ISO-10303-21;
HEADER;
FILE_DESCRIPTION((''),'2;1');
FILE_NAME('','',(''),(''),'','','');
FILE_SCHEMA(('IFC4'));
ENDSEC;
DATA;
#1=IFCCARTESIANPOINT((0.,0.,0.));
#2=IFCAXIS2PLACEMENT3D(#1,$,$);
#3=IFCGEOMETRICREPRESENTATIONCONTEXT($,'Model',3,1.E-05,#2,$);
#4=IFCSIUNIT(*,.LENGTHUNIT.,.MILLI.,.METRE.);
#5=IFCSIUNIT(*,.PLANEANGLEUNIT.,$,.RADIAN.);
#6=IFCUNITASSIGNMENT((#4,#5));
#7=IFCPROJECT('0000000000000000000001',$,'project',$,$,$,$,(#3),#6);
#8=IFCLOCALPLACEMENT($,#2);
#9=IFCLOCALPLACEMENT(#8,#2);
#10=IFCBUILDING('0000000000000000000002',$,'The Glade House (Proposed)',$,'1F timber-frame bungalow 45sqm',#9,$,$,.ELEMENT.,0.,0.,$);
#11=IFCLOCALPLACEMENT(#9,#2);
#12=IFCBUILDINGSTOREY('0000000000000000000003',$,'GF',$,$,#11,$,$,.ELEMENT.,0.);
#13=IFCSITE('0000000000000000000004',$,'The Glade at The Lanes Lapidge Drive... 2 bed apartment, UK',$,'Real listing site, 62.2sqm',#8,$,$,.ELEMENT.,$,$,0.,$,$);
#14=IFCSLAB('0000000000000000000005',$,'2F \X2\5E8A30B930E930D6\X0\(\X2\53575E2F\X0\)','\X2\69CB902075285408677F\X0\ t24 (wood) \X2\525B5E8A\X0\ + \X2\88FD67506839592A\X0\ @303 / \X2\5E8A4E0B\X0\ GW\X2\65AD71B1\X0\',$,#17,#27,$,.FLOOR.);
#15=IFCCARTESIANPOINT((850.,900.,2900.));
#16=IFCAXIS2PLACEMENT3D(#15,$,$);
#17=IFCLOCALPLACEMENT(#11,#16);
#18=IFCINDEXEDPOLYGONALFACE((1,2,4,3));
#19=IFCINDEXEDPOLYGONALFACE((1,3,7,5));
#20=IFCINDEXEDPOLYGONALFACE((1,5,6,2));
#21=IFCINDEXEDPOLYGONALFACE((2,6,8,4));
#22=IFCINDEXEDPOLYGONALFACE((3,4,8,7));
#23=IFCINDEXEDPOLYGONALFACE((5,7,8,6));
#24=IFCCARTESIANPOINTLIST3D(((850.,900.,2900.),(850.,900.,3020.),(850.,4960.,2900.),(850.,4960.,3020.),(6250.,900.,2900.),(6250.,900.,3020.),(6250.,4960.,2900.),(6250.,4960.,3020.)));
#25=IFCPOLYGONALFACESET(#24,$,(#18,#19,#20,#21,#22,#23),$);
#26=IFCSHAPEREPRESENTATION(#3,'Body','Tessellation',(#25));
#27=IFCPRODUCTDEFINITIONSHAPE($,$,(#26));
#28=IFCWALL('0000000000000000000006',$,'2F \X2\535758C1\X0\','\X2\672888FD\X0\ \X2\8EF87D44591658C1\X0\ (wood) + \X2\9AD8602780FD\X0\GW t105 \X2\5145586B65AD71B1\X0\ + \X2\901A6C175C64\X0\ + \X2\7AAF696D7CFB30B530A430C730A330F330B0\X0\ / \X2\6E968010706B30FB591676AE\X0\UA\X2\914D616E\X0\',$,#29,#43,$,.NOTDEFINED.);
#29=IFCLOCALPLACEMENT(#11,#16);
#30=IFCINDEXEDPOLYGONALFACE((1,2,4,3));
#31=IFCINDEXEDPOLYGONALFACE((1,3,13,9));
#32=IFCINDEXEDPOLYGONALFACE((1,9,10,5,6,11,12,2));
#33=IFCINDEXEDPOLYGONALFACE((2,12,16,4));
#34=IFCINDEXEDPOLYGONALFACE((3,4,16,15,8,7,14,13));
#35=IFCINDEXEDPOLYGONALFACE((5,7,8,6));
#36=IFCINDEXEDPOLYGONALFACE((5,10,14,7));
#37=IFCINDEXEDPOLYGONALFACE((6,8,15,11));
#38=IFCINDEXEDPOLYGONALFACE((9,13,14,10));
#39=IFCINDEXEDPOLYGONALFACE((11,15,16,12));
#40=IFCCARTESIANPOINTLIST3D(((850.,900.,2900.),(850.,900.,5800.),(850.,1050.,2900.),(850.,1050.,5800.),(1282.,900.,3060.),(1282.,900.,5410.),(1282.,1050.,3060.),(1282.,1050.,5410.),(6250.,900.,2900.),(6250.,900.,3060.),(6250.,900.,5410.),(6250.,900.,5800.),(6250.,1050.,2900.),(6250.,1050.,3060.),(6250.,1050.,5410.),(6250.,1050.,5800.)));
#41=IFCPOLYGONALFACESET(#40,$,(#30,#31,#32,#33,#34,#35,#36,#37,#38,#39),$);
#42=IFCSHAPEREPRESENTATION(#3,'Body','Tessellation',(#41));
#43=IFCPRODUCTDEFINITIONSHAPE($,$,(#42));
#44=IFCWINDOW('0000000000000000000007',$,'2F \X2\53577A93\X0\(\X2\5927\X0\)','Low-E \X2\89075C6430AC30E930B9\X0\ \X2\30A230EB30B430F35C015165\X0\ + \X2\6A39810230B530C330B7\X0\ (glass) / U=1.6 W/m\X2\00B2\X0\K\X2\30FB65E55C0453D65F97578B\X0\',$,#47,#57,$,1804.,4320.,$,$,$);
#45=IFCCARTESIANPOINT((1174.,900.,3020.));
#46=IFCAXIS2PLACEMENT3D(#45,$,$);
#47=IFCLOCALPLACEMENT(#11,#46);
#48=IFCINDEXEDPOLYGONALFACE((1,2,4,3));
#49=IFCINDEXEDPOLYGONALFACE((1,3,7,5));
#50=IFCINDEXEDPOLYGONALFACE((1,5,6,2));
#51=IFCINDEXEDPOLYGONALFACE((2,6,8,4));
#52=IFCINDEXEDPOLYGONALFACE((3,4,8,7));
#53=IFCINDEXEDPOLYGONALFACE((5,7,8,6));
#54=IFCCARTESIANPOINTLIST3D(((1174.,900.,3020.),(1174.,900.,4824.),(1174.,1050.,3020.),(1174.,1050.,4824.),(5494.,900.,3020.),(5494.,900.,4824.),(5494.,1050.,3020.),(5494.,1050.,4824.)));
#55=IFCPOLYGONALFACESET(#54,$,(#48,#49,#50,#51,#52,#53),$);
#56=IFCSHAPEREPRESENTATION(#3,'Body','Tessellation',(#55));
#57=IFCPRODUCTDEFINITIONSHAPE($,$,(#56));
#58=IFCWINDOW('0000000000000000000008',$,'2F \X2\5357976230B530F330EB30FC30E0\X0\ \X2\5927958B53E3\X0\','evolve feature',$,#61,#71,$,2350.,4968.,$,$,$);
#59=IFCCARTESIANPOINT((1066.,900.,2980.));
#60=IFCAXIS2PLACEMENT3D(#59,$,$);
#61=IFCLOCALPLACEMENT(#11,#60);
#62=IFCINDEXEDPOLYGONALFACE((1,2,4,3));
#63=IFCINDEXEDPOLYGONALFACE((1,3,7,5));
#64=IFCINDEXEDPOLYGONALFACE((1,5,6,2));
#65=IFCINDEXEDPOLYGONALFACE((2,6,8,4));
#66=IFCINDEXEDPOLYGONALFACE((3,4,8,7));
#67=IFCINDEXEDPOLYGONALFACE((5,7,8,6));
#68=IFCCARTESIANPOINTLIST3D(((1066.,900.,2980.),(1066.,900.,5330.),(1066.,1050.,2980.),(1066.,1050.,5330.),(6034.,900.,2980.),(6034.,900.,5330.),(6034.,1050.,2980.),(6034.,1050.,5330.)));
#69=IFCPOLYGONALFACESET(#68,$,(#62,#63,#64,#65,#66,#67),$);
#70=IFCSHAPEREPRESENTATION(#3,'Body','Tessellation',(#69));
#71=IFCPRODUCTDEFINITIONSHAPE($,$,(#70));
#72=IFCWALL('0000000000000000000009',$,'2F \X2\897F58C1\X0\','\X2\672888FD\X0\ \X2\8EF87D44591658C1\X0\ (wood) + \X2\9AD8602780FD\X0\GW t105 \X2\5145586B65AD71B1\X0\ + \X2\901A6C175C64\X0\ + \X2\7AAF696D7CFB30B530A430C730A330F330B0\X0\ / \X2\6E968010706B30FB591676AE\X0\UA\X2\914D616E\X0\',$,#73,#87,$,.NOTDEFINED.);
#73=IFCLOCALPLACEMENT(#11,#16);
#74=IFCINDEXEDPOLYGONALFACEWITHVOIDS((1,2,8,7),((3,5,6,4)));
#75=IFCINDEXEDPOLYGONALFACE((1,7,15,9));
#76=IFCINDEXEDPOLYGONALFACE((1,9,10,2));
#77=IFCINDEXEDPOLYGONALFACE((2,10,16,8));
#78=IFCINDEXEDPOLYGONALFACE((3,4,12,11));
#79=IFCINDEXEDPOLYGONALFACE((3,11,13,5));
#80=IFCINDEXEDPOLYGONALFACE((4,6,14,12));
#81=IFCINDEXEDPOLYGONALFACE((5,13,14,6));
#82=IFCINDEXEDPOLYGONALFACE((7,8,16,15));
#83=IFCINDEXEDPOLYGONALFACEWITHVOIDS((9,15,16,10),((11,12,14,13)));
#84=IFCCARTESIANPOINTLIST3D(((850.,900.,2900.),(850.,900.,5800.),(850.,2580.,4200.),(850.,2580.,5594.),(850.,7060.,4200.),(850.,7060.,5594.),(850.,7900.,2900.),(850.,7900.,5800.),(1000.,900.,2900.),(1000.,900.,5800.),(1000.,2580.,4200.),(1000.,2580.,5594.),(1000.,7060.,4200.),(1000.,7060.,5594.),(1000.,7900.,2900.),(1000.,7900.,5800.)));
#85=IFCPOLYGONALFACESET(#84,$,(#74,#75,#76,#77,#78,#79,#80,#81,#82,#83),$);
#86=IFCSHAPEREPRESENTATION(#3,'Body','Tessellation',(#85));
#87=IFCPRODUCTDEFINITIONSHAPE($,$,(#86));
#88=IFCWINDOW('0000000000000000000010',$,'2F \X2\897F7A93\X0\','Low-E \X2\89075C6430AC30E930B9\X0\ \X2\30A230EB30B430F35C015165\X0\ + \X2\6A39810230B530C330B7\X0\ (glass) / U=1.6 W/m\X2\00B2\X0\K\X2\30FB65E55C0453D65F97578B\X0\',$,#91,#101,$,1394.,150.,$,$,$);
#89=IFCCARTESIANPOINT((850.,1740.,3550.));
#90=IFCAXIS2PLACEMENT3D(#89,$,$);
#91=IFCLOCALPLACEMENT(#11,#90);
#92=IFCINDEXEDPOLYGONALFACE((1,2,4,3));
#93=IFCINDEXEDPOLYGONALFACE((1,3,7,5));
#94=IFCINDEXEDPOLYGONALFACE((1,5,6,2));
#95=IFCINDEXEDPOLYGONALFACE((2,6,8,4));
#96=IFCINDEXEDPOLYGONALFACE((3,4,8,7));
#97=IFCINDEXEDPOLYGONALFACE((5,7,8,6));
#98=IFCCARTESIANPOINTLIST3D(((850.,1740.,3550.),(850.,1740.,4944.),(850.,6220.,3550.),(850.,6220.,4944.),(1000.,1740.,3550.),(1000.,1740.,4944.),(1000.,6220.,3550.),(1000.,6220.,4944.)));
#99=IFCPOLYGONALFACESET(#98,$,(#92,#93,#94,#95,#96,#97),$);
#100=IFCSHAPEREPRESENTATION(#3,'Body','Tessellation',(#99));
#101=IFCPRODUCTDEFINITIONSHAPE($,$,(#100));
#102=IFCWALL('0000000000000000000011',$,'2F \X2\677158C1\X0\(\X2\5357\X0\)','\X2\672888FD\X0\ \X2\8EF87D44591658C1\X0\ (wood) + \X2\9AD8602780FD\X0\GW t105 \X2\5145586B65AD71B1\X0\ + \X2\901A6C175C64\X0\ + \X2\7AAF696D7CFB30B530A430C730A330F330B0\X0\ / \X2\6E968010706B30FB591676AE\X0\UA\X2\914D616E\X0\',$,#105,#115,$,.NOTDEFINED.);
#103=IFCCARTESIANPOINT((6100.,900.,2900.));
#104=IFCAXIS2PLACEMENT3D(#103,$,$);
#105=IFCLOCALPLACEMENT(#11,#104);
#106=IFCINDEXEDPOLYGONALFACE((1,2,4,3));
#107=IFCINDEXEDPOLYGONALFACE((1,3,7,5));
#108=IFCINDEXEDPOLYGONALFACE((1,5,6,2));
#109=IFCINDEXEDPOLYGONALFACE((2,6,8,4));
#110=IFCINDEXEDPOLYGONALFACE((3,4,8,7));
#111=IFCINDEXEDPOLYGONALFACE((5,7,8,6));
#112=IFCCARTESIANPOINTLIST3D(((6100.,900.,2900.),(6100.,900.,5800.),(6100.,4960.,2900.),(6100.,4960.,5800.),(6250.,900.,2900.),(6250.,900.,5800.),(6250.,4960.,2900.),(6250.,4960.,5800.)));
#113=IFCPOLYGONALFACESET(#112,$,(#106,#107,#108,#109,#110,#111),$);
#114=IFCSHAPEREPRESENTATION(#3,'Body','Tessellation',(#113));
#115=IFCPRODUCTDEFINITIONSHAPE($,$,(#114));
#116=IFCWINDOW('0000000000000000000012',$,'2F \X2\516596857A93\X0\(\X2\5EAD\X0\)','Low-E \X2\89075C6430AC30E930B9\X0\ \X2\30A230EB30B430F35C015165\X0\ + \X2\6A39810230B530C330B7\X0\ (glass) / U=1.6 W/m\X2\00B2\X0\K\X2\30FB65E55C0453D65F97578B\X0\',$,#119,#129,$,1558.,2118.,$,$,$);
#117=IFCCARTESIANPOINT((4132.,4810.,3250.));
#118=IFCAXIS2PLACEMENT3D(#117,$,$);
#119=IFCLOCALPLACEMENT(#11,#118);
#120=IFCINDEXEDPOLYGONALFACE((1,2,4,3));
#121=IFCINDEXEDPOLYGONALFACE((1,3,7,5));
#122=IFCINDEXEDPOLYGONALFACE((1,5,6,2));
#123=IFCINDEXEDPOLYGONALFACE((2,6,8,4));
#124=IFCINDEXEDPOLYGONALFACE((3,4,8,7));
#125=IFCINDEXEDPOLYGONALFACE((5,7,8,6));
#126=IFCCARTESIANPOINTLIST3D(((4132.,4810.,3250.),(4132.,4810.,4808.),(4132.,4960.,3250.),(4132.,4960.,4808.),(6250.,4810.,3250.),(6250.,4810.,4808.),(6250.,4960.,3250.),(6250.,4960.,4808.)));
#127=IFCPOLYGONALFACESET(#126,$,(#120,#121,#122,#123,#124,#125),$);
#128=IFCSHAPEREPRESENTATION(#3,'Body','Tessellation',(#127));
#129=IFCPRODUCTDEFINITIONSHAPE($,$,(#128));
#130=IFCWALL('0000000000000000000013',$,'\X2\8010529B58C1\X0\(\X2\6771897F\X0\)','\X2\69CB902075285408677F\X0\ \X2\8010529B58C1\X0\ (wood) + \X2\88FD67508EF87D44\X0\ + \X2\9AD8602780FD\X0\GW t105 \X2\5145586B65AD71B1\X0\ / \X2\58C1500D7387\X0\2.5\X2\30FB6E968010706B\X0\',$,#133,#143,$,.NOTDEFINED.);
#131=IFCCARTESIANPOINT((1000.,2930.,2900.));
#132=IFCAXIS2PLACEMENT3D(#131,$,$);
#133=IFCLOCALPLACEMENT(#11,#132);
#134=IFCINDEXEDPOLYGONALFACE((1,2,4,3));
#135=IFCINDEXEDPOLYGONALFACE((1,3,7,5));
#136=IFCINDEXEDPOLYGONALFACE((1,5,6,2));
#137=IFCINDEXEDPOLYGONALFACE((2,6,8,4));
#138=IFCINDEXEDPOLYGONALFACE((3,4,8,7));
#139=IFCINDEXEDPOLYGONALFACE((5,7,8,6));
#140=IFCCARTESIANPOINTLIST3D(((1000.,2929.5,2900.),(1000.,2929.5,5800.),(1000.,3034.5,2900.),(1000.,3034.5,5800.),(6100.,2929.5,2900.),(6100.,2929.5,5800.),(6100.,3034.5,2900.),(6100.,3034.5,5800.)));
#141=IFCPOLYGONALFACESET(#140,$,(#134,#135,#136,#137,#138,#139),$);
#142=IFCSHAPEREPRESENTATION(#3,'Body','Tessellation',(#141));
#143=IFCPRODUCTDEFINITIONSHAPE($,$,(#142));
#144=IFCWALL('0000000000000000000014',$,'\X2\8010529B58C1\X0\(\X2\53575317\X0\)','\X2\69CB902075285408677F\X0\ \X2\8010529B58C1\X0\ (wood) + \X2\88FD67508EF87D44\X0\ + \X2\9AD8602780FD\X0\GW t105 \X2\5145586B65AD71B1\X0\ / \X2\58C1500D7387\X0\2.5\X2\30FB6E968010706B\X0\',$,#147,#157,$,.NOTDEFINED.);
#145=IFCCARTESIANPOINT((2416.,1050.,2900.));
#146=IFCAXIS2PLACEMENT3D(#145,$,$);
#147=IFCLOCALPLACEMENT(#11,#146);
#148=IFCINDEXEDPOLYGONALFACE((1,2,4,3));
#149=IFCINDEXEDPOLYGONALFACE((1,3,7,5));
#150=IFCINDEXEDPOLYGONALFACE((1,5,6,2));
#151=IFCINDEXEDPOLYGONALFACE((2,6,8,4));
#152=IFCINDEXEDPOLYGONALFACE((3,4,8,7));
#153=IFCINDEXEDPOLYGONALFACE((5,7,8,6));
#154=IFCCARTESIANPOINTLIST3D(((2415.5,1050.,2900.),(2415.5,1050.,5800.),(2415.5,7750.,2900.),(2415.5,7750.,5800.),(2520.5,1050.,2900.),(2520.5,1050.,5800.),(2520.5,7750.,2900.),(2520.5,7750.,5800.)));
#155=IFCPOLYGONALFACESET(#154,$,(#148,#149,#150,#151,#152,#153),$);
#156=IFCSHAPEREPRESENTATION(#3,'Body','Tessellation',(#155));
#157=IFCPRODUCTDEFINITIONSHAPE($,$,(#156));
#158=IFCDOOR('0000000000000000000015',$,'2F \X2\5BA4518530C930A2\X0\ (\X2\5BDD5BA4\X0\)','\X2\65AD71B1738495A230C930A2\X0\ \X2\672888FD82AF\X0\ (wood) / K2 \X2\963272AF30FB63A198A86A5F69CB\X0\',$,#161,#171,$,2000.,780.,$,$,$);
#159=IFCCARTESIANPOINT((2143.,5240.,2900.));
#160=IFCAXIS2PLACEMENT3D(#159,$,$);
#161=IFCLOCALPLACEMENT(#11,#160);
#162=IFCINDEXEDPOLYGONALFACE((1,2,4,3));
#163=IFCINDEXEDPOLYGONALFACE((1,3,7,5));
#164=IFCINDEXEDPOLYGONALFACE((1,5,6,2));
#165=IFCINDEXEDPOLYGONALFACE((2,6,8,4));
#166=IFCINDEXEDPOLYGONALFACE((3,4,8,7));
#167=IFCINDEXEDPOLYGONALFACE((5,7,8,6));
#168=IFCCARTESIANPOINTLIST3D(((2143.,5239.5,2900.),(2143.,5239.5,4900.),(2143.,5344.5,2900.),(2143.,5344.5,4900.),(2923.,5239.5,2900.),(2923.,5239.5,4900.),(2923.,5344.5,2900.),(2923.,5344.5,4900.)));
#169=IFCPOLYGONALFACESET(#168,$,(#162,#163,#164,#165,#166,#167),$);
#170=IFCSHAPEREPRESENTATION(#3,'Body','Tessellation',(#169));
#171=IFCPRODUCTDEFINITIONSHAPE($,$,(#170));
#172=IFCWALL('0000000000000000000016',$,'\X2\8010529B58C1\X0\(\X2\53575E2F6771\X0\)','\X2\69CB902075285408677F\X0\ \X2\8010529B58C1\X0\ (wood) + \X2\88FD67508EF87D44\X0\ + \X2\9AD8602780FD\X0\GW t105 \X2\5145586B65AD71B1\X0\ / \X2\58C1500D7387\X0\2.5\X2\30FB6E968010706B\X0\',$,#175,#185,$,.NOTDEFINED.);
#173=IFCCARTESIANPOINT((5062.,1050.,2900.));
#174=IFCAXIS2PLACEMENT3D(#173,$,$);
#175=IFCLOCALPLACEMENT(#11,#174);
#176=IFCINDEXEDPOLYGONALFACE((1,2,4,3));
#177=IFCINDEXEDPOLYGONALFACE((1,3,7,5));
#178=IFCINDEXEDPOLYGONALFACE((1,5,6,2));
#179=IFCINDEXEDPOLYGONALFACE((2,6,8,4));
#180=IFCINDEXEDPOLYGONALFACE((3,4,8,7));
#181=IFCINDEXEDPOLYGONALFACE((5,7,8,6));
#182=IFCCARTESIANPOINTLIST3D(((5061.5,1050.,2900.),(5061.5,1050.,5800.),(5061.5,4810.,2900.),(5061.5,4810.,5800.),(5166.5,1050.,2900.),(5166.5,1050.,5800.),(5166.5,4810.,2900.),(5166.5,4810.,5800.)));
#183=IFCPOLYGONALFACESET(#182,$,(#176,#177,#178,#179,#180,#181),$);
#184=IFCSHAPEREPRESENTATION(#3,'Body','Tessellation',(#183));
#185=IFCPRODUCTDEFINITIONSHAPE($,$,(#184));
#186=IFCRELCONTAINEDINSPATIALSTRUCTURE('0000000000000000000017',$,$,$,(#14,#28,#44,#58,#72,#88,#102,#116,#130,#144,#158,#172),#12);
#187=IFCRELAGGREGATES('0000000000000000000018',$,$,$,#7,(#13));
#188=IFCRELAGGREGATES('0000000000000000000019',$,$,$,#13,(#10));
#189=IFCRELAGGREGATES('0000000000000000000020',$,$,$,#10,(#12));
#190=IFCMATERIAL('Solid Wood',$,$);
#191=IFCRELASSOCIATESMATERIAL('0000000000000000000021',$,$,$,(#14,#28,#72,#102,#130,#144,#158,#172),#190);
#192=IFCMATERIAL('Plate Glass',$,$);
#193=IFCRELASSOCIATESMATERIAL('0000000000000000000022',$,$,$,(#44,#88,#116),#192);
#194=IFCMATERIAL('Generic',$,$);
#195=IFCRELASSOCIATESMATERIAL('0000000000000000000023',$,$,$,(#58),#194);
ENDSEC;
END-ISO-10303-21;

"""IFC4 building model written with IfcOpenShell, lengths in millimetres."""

from ifc_helpers import new_model, si_unit, frame, frame_2d, origin, place, context, project, spatial, rectangle, extrude, material, element, fill, save


model = new_model("IFC4")

# Units and contexts
model_context = context("Model", 3, precision=1e-05, world=origin())
ifc_project = project(units=[si_unit("LENGTHUNIT", "METRE", prefix="MILLI"), si_unit("PLANEANGLEUNIT", "RADIAN")], contexts=[model_context])

# Site, building, storey
site_placement = place(None, origin())
site = spatial("IfcSite", under=ifc_project, at=site_placement, Name="The Glade at The Lanes Lapidge Drive... 2 bed apartment, UK", ObjectType="Real listing site, 62.2sqm", CompositionType="ELEMENT", RefElevation=0.0)
building_placement = place(site_placement, origin())
building = spatial("IfcBuilding", under=site, at=building_placement, Name="The Glade House (Proposed)", ObjectType="1F timber-frame bungalow 45sqm", CompositionType="ELEMENT", ElevationOfRefHeight=0.0, ElevationOfTerrain=0.0)
storey_placement = place(building_placement, origin())
storey = spatial("IfcBuildingStorey", under=building, at=storey_placement, Name="GF", CompositionType="ELEMENT", Elevation=0.0)

# Slab
ifc_material_1 = material(Name="Solid Wood")
slab_placement = place(storey_placement, frame((850.0, 900.0, 2900.0)))
element("IfcSlab", 1, at=slab_placement, inside=storey, material=ifc_material_1, Name="2F 床スラブ(南帯)", Description="構造用合板 t24 (wood) 剛床 + 製材根太 @303 / 床下 GW断熱", PredefinedType="FLOOR", context=model_context, shape_type="SweptSolid", body=[
    extrude(rectangle(XDim=5400.0, YDim=4060.0, at=frame_2d((2700.0, 2030.0))), frame((850.0, 900.0, 2900.0)), (0.0, 0.0, 1.0), 120.0),
])

# Wall, openings, windows
wall_1_placement = place(storey_placement, frame((850.0, 900.0, 2900.0)))
wall_1 = element("IfcWall", 2, at=wall_1_placement, inside=storey, material=ifc_material_1, Name="2F 南壁", Description="木製 軸組外壁 (wood) + 高性能GW t105 充填断熱 + 通気層 + 窯業系サイディング / 準耐火・外皮UA配慮", PredefinedType="NOTDEFINED", context=model_context, shape_type="SweptSolid", body=[
    extrude(rectangle(XDim=5400.0, YDim=150.0, at=frame_2d((2700.0, 75.0))), frame((850.0, 900.0, 2900.0)), (0.0, 0.0, 1.0), 2900.0),
])
opening_1_placement = place(storey_placement, frame((1174.0, 900.0, 3020.0)))
opening_1 = element("IfcOpeningElement", 3, at=opening_1_placement, cuts=wall_1, PredefinedType="NOTDEFINED", context=model_context, shape_type="SweptSolid", body=[
    extrude(rectangle(XDim=4320.0, YDim=150.0, at=frame_2d((2160.0, 75.0))), frame((1174.0, 900.0, 3020.0)), (0.0, 0.0, 1.0), 1804.0),
])
opening_2_placement = place(storey_placement, frame((1066.0, 900.0, 2980.0)))
opening_2 = element("IfcOpeningElement", 4, at=opening_2_placement, cuts=wall_1, PredefinedType="NOTDEFINED", context=model_context, shape_type="SweptSolid", body=[
    extrude(rectangle(XDim=4968.0, YDim=150.0, at=frame_2d((2484.0, 75.0))), frame((1066.0, 900.0, 2980.0)), (0.0, 0.0, 1.0), 2350.0),
])
ifc_material_2 = material(Name="Plate Glass")
window_1_placement = place(storey_placement, frame((1174.0, 900.0, 3020.0)))
window_1 = element("IfcWindow", 5, at=window_1_placement, inside=storey, material=ifc_material_2, Name="2F 南窓(大)", Description="Low-E 複層ガラス アルゴン封入 + 樹脂サッシ (glass) / U=1.6 W/m²K・日射取得型", OverallHeight=1804.0, OverallWidth=4320.0, context=model_context, shape_type="SweptSolid", body=[
    extrude(rectangle(XDim=4320.0, YDim=150.0, at=frame_2d((2160.0, 75.0))), frame((1174.0, 900.0, 3020.0)), (0.0, 0.0, 1.0), 1804.0),
])
fill(opening_1, window_1)
ifc_material_3 = material(Name="Generic")
window_2_placement = place(storey_placement, frame((1066.0, 900.0, 2980.0)))
window_2 = element("IfcWindow", 6, at=window_2_placement, inside=storey, material=ifc_material_3, Name="2F 南面サンルーム 大開口", Description="evolve feature", OverallHeight=2350.0, OverallWidth=4968.0, context=model_context, shape_type="SweptSolid", body=[
    extrude(rectangle(XDim=4968.0, YDim=150.0, at=frame_2d((2484.0, 75.0))), frame((1066.0, 900.0, 2980.0)), (0.0, 0.0, 1.0), 2350.0),
])
fill(opening_2, window_2)

# Walls, openings, windows
wall_2_placement = place(storey_placement, frame((850.0, 900.0, 2900.0)))
wall_2 = element("IfcWall", 7, at=wall_2_placement, inside=storey, material=ifc_material_1, Name="2F 西壁", Description="木製 軸組外壁 (wood) + 高性能GW t105 充填断熱 + 通気層 + 窯業系サイディング / 準耐火・外皮UA配慮", PredefinedType="NOTDEFINED", context=model_context, shape_type="SweptSolid", body=[
    extrude(rectangle(XDim=150.0, YDim=7000.0, at=frame_2d((75.0, 3500.0))), frame((850.0, 900.0, 2900.0)), (0.0, 0.0, 1.0), 2900.0),
])
opening_3_placement = place(storey_placement, frame((850.0, 1740.0, 3550.0)))
opening_3 = element("IfcOpeningElement", 8, at=opening_3_placement, cuts=wall_2, PredefinedType="NOTDEFINED", context=model_context, shape_type="SweptSolid", body=[
    extrude(rectangle(XDim=150.0, YDim=4480.0, at=frame_2d((75.0, 2240.0))), frame((850.0, 1740.0, 3550.0)), (0.0, 0.0, 1.0), 1394.0),
])
window_3_placement = place(storey_placement, frame((850.0, 1740.0, 3550.0)))
window_3 = element("IfcWindow", 9, at=window_3_placement, inside=storey, material=ifc_material_2, Name="2F 西窓", Description="Low-E 複層ガラス アルゴン封入 + 樹脂サッシ (glass) / U=1.6 W/m²K・日射取得型", OverallHeight=1394.0, OverallWidth=150.0, context=model_context, shape_type="SweptSolid", body=[
    extrude(rectangle(XDim=150.0, YDim=4480.0, at=frame_2d((75.0, 2240.0))), frame((850.0, 1740.0, 3550.0)), (0.0, 0.0, 1.0), 1394.0),
])
fill(opening_3, window_3)
wall_3_placement = place(storey_placement, frame((6100.0, 900.0, 2900.0)))
wall_3 = element("IfcWall", 10, at=wall_3_placement, inside=storey, material=ifc_material_1, Name="2F 東壁(南)", Description="木製 軸組外壁 (wood) + 高性能GW t105 充填断熱 + 通気層 + 窯業系サイディング / 準耐火・外皮UA配慮", PredefinedType="NOTDEFINED", context=model_context, shape_type="SweptSolid", body=[
    extrude(rectangle(XDim=150.0, YDim=4060.0, at=frame_2d((75.0, 2030.0))), frame((6100.0, 900.0, 2900.0)), (0.0, 0.0, 1.0), 2900.0),
])
opening_4_placement = place(storey_placement, frame((4132.0, 4810.0, 3250.0)))
opening_4 = element("IfcOpeningElement", 11, at=opening_4_placement, cuts=wall_3, PredefinedType="NOTDEFINED", context=model_context, shape_type="SweptSolid", body=[
    extrude(rectangle(XDim=2118.0, YDim=150.0, at=frame_2d((1059.0, 75.0))), frame((4132.0, 4810.0, 3250.0)), (0.0, 0.0, 1.0), 1558.0),
])
window_4_placement = place(storey_placement, frame((4132.0, 4810.0, 3250.0)))
window_4 = element("IfcWindow", 12, at=window_4_placement, inside=storey, material=ifc_material_2, Name="2F 入隅窓(庭)", Description="Low-E 複層ガラス アルゴン封入 + 樹脂サッシ (glass) / U=1.6 W/m²K・日射取得型", OverallHeight=1558.0, OverallWidth=2118.0, context=model_context, shape_type="SweptSolid", body=[
    extrude(rectangle(XDim=2118.0, YDim=150.0, at=frame_2d((1059.0, 75.0))), frame((4132.0, 4810.0, 3250.0)), (0.0, 0.0, 1.0), 1558.0),
])
fill(opening_4, window_4)

# Wall
wall_4_placement = place(storey_placement, frame((1000.0, 2930.0, 2900.0)))
element("IfcWall", 13, at=wall_4_placement, inside=storey, material=ifc_material_1, Name="耐力壁(東西)", Description="構造用合板 耐力壁 (wood) + 製材軸組 + 高性能GW t105 充填断熱 / 壁倍率2.5・準耐火", PredefinedType="NOTDEFINED", context=model_context, shape_type="SweptSolid", body=[
    extrude(rectangle(XDim=5100.0, YDim=105.0, at=frame_2d((2550.0, 52.0))), frame((1000.0, 2930.0, 2900.0)), (0.0, 0.0, 1.0), 2900.0),
])

# Wall, opening, door
wall_5_placement = place(storey_placement, frame((2416.0, 1050.0, 2900.0)))
wall_5 = element("IfcWall", 14, at=wall_5_placement, inside=storey, material=ifc_material_1, Name="耐力壁(南北)", Description="構造用合板 耐力壁 (wood) + 製材軸組 + 高性能GW t105 充填断熱 / 壁倍率2.5・準耐火", PredefinedType="NOTDEFINED", context=model_context, shape_type="SweptSolid", body=[
    extrude(rectangle(XDim=105.0, YDim=6700.0, at=frame_2d((52.0, 3350.0))), frame((2416.0, 1050.0, 2900.0)), (0.0, 0.0, 1.0), 2900.0),
])
opening_5_placement = place(storey_placement, frame((2143.0, 5240.0, 2900.0)))
opening_5 = element("IfcOpeningElement", 15, at=opening_5_placement, cuts=wall_5, PredefinedType="NOTDEFINED", context=model_context, shape_type="SweptSolid", body=[
    extrude(rectangle(XDim=780.0, YDim=105.0, at=frame_2d((390.0, 52.0))), frame((2143.0, 5240.0, 2900.0)), (0.0, 0.0, 1.0), 2000.0),
])
door_placement = place(storey_placement, frame((2143.0, 5240.0, 2900.0)))
door = element("IfcDoor", 16, at=door_placement, inside=storey, material=ifc_material_1, Name="2F 室内ドア (寝室)", Description="断熱玄関ドア 木製芯 (wood) / K2 防犯・採風機構", OverallHeight=2000.0, OverallWidth=780.0, context=model_context, shape_type="SweptSolid", body=[
    extrude(rectangle(XDim=780.0, YDim=105.0, at=frame_2d((390.0, 52.0))), frame((2143.0, 5240.0, 2900.0)), (0.0, 0.0, 1.0), 2000.0),
])
fill(opening_5, door)

# Wall
wall_6_placement = place(storey_placement, frame((5062.0, 1050.0, 2900.0)))
element("IfcWall", 17, at=wall_6_placement, inside=storey, material=ifc_material_1, Name="耐力壁(南帯東)", Description="構造用合板 耐力壁 (wood) + 製材軸組 + 高性能GW t105 充填断熱 / 壁倍率2.5・準耐火", PredefinedType="NOTDEFINED", context=model_context, shape_type="SweptSolid", body=[
    extrude(rectangle(XDim=105.0, YDim=3760.0, at=frame_2d((52.0, 1880.0))), frame((5062.0, 1050.0, 2900.0)), (0.0, 0.0, 1.0), 2900.0),
])

save(model, "model.ifc")
